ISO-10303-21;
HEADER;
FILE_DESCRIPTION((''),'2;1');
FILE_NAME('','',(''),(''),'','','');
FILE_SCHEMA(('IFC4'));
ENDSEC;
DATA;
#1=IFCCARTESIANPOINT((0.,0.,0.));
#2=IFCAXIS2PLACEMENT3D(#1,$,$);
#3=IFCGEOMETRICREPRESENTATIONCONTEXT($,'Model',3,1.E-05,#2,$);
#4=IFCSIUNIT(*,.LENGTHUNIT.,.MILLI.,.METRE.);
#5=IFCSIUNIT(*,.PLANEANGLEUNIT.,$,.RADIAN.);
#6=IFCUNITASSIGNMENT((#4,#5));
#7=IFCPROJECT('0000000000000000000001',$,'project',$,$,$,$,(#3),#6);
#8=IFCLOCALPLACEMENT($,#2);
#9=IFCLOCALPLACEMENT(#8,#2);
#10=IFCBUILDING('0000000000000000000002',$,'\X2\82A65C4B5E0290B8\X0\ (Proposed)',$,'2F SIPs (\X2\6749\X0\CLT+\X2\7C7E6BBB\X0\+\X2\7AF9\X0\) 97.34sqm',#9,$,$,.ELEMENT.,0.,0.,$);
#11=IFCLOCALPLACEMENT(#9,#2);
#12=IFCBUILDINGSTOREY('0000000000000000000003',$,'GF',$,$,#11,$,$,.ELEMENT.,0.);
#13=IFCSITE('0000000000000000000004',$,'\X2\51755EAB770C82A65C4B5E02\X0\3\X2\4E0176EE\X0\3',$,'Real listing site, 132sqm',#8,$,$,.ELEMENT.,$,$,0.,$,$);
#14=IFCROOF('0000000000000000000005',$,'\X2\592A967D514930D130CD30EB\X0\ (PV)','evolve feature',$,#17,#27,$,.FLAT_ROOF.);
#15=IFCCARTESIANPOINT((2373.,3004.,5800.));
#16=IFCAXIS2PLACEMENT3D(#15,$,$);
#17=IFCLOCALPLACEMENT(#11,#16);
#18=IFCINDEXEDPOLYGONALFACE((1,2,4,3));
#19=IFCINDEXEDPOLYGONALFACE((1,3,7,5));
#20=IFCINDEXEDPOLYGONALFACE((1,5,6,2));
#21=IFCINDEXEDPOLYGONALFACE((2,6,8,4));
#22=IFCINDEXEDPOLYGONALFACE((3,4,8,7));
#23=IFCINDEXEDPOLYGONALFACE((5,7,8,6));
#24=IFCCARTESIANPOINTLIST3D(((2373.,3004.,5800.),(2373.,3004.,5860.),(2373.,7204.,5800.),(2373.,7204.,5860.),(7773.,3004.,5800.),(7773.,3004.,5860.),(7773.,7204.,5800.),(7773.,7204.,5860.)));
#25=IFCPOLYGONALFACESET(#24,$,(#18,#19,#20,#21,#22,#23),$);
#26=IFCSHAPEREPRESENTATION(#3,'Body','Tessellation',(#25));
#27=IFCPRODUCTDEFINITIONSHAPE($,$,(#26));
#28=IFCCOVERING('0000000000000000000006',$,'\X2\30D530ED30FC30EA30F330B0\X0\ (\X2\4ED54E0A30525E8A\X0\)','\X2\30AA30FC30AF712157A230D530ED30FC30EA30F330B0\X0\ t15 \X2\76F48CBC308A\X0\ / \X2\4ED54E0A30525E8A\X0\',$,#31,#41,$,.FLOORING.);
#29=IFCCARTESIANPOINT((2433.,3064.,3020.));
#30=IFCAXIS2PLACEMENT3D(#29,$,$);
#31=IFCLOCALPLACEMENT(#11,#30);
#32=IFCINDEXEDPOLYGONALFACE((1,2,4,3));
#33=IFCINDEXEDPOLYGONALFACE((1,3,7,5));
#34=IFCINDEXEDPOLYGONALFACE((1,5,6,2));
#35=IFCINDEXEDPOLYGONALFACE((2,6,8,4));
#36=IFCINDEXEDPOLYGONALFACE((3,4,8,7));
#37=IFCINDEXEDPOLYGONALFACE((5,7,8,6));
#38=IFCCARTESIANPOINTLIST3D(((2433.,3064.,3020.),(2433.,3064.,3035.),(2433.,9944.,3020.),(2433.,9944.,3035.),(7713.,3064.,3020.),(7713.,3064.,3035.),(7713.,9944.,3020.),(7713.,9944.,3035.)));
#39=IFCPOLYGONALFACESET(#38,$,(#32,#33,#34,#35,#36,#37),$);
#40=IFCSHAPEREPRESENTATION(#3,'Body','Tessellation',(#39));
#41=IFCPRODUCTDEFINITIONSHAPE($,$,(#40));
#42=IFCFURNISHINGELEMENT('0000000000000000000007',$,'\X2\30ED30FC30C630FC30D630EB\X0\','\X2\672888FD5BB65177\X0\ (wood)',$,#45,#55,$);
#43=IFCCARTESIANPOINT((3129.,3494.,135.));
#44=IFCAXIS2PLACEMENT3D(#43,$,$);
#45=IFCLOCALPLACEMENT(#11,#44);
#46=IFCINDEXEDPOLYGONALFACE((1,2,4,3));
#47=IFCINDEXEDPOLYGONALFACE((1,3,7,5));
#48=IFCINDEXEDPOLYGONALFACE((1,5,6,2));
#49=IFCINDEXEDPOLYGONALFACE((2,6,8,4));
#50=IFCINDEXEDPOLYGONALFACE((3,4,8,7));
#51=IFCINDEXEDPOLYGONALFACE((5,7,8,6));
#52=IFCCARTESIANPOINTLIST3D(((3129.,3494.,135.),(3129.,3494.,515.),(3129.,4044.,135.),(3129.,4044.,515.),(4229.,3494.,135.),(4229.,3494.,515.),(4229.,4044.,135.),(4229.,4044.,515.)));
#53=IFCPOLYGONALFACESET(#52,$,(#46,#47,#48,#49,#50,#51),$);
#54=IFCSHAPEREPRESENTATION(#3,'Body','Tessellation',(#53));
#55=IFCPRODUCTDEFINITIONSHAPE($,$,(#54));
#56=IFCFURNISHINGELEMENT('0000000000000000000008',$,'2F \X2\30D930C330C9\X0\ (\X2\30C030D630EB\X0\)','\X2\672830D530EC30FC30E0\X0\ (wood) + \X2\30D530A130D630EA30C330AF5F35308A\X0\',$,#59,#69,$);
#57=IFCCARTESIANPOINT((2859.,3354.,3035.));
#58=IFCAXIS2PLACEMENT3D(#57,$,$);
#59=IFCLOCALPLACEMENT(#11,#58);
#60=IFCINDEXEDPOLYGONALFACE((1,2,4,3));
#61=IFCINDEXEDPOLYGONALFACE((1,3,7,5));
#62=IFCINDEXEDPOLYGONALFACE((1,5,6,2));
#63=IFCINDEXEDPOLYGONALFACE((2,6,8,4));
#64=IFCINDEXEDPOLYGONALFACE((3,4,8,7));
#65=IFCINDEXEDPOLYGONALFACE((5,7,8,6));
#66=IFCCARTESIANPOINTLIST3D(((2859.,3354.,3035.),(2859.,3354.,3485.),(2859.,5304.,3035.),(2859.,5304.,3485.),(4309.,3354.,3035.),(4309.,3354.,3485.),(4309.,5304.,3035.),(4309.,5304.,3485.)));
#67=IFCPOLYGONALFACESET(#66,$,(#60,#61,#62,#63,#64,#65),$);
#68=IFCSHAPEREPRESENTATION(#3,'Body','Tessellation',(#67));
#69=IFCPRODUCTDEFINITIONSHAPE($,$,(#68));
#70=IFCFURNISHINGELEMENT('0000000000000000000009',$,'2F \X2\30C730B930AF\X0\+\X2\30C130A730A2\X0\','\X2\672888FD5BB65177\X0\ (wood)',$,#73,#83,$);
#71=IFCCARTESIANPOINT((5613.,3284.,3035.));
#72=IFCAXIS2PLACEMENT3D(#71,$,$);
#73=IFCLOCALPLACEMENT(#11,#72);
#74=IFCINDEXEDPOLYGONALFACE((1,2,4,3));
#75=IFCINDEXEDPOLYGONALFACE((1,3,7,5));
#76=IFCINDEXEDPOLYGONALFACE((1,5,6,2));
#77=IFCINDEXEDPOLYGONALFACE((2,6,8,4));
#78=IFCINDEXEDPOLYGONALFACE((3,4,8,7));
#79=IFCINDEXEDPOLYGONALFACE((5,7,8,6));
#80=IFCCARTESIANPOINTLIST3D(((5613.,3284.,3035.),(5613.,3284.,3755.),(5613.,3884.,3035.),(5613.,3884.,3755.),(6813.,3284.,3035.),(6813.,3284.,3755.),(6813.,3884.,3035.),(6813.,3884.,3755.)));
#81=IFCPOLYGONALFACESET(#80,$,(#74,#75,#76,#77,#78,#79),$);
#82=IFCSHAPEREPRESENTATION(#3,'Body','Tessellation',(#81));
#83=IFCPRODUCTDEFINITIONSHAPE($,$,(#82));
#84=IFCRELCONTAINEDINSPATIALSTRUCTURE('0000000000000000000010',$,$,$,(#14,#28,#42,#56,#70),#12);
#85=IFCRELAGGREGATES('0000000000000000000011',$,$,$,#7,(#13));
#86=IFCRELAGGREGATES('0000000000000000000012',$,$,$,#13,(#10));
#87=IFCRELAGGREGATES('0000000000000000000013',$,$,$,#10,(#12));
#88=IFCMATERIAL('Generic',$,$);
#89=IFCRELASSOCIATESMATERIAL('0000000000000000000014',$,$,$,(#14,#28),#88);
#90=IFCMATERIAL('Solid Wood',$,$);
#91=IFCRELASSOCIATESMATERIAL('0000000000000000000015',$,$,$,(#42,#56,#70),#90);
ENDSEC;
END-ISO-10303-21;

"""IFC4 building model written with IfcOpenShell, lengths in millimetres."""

from ifc_helpers import new_model, si_unit, frame, frame_2d, origin, place, context, project, spatial, rectangle, extrude, material, element, save


model = new_model("IFC4")

# Units and contexts
model_context = context("Model", 3, precision=1e-05, world=origin())
ifc_project = project(units=[si_unit("LENGTHUNIT", "METRE", prefix="MILLI"), si_unit("PLANEANGLEUNIT", "RADIAN")], contexts=[model_context])

# Site, building, storey
site_placement = place(None, origin())
site = spatial("IfcSite", under=ifc_project, at=site_placement, Name="兵庫県芦屋市3丁目3", ObjectType="Real listing site, 132sqm", CompositionType="ELEMENT", RefElevation=0.0)
building_placement = place(site_placement, origin())
building = spatial("IfcBuilding", under=site, at=building_placement, Name="芦屋市邸 (Proposed)", ObjectType="2F SIPs (杉CLT+籾殻+竹) 97.34sqm", CompositionType="ELEMENT", ElevationOfRefHeight=0.0, ElevationOfTerrain=0.0)
storey_placement = place(building_placement, origin())
storey = spatial("IfcBuildingStorey", under=building, at=storey_placement, Name="GF", CompositionType="ELEMENT", Elevation=0.0)

# Shared definitions
ifc_material_1 = material(Name="Solid Wood")

# Shared definitions
ifc_material_2 = material(Name="Generic")

# Roof
roof_1_placement = place(storey_placement, frame((2373.0, 3004.0, 5800.0)))
element("IfcRoof", 1, at=roof_1_placement, inside=storey, material=ifc_material_2, Name="太陽光パネル (PV)", Description="evolve feature", PredefinedType="FLAT_ROOF", context=model_context, shape_type="SweptSolid", body=[
    extrude(rectangle(XDim=5400.0, YDim=4200.0, at=frame_2d((2700.0, 2100.0))), frame((2373.0, 3004.0, 5800.0)), (0.0, 0.0, 1.0), 60.0),
])

# Covering
covering_placement = place(storey_placement, frame((2433.0, 3064.0, 3020.0)))
element("IfcCovering", 2, at=covering_placement, inside=storey, material=ifc_material_2, Name="フローリング (仕上げ床)", Description="オーク無垢フローリング t15 直貼り / 仕上げ床", PredefinedType="FLOORING", context=model_context, shape_type="SweptSolid", body=[
    extrude(rectangle(XDim=5280.0, YDim=6880.0, at=frame_2d((2640.0, 3440.0))), frame((2433.0, 3064.0, 3020.0)), (0.0, 0.0, 1.0), 15.0),
])

# Furnishing elements
furnishing_1_placement = place(storey_placement, frame((3129.0, 3494.0, 135.0)))
element("IfcFurnishingElement", 3, at=furnishing_1_placement, inside=storey, material=ifc_material_1, Name="ローテーブル", Description="木製家具 (wood)", context=model_context, shape_type="SweptSolid", body=[
    extrude(rectangle(XDim=1100.0, YDim=550.0, at=frame_2d((550.0, 275.0))), frame((3129.0, 3494.0, 135.0)), (0.0, 0.0, 1.0), 380.0),
])
furnishing_2_placement = place(storey_placement, frame((2859.0, 3354.0, 3035.0)))
element("IfcFurnishingElement", 4, at=furnishing_2_placement, inside=storey, material=ifc_material_1, Name="2F ベッド (ダブル)", Description="木フレーム (wood) + ファブリック張り", context=model_context, shape_type="SweptSolid", body=[
    extrude(rectangle(XDim=1450.0, YDim=1950.0, at=frame_2d((725.0, 975.0))), frame((2859.0, 3354.0, 3035.0)), (0.0, 0.0, 1.0), 450.0),
])
furnishing_3_placement = place(storey_placement, frame((5613.0, 3284.0, 3035.0)))
element("IfcFurnishingElement", 5, at=furnishing_3_placement, inside=storey, material=ifc_material_1, Name="2F デスク+チェア", Description="木製家具 (wood)", context=model_context, shape_type="SweptSolid", body=[
    extrude(rectangle(XDim=1200.0, YDim=600.0, at=frame_2d((600.0, 300.0))), frame((5613.0, 3284.0, 3035.0)), (0.0, 0.0, 1.0), 720.0),
])

save(model, "model.ifc")
